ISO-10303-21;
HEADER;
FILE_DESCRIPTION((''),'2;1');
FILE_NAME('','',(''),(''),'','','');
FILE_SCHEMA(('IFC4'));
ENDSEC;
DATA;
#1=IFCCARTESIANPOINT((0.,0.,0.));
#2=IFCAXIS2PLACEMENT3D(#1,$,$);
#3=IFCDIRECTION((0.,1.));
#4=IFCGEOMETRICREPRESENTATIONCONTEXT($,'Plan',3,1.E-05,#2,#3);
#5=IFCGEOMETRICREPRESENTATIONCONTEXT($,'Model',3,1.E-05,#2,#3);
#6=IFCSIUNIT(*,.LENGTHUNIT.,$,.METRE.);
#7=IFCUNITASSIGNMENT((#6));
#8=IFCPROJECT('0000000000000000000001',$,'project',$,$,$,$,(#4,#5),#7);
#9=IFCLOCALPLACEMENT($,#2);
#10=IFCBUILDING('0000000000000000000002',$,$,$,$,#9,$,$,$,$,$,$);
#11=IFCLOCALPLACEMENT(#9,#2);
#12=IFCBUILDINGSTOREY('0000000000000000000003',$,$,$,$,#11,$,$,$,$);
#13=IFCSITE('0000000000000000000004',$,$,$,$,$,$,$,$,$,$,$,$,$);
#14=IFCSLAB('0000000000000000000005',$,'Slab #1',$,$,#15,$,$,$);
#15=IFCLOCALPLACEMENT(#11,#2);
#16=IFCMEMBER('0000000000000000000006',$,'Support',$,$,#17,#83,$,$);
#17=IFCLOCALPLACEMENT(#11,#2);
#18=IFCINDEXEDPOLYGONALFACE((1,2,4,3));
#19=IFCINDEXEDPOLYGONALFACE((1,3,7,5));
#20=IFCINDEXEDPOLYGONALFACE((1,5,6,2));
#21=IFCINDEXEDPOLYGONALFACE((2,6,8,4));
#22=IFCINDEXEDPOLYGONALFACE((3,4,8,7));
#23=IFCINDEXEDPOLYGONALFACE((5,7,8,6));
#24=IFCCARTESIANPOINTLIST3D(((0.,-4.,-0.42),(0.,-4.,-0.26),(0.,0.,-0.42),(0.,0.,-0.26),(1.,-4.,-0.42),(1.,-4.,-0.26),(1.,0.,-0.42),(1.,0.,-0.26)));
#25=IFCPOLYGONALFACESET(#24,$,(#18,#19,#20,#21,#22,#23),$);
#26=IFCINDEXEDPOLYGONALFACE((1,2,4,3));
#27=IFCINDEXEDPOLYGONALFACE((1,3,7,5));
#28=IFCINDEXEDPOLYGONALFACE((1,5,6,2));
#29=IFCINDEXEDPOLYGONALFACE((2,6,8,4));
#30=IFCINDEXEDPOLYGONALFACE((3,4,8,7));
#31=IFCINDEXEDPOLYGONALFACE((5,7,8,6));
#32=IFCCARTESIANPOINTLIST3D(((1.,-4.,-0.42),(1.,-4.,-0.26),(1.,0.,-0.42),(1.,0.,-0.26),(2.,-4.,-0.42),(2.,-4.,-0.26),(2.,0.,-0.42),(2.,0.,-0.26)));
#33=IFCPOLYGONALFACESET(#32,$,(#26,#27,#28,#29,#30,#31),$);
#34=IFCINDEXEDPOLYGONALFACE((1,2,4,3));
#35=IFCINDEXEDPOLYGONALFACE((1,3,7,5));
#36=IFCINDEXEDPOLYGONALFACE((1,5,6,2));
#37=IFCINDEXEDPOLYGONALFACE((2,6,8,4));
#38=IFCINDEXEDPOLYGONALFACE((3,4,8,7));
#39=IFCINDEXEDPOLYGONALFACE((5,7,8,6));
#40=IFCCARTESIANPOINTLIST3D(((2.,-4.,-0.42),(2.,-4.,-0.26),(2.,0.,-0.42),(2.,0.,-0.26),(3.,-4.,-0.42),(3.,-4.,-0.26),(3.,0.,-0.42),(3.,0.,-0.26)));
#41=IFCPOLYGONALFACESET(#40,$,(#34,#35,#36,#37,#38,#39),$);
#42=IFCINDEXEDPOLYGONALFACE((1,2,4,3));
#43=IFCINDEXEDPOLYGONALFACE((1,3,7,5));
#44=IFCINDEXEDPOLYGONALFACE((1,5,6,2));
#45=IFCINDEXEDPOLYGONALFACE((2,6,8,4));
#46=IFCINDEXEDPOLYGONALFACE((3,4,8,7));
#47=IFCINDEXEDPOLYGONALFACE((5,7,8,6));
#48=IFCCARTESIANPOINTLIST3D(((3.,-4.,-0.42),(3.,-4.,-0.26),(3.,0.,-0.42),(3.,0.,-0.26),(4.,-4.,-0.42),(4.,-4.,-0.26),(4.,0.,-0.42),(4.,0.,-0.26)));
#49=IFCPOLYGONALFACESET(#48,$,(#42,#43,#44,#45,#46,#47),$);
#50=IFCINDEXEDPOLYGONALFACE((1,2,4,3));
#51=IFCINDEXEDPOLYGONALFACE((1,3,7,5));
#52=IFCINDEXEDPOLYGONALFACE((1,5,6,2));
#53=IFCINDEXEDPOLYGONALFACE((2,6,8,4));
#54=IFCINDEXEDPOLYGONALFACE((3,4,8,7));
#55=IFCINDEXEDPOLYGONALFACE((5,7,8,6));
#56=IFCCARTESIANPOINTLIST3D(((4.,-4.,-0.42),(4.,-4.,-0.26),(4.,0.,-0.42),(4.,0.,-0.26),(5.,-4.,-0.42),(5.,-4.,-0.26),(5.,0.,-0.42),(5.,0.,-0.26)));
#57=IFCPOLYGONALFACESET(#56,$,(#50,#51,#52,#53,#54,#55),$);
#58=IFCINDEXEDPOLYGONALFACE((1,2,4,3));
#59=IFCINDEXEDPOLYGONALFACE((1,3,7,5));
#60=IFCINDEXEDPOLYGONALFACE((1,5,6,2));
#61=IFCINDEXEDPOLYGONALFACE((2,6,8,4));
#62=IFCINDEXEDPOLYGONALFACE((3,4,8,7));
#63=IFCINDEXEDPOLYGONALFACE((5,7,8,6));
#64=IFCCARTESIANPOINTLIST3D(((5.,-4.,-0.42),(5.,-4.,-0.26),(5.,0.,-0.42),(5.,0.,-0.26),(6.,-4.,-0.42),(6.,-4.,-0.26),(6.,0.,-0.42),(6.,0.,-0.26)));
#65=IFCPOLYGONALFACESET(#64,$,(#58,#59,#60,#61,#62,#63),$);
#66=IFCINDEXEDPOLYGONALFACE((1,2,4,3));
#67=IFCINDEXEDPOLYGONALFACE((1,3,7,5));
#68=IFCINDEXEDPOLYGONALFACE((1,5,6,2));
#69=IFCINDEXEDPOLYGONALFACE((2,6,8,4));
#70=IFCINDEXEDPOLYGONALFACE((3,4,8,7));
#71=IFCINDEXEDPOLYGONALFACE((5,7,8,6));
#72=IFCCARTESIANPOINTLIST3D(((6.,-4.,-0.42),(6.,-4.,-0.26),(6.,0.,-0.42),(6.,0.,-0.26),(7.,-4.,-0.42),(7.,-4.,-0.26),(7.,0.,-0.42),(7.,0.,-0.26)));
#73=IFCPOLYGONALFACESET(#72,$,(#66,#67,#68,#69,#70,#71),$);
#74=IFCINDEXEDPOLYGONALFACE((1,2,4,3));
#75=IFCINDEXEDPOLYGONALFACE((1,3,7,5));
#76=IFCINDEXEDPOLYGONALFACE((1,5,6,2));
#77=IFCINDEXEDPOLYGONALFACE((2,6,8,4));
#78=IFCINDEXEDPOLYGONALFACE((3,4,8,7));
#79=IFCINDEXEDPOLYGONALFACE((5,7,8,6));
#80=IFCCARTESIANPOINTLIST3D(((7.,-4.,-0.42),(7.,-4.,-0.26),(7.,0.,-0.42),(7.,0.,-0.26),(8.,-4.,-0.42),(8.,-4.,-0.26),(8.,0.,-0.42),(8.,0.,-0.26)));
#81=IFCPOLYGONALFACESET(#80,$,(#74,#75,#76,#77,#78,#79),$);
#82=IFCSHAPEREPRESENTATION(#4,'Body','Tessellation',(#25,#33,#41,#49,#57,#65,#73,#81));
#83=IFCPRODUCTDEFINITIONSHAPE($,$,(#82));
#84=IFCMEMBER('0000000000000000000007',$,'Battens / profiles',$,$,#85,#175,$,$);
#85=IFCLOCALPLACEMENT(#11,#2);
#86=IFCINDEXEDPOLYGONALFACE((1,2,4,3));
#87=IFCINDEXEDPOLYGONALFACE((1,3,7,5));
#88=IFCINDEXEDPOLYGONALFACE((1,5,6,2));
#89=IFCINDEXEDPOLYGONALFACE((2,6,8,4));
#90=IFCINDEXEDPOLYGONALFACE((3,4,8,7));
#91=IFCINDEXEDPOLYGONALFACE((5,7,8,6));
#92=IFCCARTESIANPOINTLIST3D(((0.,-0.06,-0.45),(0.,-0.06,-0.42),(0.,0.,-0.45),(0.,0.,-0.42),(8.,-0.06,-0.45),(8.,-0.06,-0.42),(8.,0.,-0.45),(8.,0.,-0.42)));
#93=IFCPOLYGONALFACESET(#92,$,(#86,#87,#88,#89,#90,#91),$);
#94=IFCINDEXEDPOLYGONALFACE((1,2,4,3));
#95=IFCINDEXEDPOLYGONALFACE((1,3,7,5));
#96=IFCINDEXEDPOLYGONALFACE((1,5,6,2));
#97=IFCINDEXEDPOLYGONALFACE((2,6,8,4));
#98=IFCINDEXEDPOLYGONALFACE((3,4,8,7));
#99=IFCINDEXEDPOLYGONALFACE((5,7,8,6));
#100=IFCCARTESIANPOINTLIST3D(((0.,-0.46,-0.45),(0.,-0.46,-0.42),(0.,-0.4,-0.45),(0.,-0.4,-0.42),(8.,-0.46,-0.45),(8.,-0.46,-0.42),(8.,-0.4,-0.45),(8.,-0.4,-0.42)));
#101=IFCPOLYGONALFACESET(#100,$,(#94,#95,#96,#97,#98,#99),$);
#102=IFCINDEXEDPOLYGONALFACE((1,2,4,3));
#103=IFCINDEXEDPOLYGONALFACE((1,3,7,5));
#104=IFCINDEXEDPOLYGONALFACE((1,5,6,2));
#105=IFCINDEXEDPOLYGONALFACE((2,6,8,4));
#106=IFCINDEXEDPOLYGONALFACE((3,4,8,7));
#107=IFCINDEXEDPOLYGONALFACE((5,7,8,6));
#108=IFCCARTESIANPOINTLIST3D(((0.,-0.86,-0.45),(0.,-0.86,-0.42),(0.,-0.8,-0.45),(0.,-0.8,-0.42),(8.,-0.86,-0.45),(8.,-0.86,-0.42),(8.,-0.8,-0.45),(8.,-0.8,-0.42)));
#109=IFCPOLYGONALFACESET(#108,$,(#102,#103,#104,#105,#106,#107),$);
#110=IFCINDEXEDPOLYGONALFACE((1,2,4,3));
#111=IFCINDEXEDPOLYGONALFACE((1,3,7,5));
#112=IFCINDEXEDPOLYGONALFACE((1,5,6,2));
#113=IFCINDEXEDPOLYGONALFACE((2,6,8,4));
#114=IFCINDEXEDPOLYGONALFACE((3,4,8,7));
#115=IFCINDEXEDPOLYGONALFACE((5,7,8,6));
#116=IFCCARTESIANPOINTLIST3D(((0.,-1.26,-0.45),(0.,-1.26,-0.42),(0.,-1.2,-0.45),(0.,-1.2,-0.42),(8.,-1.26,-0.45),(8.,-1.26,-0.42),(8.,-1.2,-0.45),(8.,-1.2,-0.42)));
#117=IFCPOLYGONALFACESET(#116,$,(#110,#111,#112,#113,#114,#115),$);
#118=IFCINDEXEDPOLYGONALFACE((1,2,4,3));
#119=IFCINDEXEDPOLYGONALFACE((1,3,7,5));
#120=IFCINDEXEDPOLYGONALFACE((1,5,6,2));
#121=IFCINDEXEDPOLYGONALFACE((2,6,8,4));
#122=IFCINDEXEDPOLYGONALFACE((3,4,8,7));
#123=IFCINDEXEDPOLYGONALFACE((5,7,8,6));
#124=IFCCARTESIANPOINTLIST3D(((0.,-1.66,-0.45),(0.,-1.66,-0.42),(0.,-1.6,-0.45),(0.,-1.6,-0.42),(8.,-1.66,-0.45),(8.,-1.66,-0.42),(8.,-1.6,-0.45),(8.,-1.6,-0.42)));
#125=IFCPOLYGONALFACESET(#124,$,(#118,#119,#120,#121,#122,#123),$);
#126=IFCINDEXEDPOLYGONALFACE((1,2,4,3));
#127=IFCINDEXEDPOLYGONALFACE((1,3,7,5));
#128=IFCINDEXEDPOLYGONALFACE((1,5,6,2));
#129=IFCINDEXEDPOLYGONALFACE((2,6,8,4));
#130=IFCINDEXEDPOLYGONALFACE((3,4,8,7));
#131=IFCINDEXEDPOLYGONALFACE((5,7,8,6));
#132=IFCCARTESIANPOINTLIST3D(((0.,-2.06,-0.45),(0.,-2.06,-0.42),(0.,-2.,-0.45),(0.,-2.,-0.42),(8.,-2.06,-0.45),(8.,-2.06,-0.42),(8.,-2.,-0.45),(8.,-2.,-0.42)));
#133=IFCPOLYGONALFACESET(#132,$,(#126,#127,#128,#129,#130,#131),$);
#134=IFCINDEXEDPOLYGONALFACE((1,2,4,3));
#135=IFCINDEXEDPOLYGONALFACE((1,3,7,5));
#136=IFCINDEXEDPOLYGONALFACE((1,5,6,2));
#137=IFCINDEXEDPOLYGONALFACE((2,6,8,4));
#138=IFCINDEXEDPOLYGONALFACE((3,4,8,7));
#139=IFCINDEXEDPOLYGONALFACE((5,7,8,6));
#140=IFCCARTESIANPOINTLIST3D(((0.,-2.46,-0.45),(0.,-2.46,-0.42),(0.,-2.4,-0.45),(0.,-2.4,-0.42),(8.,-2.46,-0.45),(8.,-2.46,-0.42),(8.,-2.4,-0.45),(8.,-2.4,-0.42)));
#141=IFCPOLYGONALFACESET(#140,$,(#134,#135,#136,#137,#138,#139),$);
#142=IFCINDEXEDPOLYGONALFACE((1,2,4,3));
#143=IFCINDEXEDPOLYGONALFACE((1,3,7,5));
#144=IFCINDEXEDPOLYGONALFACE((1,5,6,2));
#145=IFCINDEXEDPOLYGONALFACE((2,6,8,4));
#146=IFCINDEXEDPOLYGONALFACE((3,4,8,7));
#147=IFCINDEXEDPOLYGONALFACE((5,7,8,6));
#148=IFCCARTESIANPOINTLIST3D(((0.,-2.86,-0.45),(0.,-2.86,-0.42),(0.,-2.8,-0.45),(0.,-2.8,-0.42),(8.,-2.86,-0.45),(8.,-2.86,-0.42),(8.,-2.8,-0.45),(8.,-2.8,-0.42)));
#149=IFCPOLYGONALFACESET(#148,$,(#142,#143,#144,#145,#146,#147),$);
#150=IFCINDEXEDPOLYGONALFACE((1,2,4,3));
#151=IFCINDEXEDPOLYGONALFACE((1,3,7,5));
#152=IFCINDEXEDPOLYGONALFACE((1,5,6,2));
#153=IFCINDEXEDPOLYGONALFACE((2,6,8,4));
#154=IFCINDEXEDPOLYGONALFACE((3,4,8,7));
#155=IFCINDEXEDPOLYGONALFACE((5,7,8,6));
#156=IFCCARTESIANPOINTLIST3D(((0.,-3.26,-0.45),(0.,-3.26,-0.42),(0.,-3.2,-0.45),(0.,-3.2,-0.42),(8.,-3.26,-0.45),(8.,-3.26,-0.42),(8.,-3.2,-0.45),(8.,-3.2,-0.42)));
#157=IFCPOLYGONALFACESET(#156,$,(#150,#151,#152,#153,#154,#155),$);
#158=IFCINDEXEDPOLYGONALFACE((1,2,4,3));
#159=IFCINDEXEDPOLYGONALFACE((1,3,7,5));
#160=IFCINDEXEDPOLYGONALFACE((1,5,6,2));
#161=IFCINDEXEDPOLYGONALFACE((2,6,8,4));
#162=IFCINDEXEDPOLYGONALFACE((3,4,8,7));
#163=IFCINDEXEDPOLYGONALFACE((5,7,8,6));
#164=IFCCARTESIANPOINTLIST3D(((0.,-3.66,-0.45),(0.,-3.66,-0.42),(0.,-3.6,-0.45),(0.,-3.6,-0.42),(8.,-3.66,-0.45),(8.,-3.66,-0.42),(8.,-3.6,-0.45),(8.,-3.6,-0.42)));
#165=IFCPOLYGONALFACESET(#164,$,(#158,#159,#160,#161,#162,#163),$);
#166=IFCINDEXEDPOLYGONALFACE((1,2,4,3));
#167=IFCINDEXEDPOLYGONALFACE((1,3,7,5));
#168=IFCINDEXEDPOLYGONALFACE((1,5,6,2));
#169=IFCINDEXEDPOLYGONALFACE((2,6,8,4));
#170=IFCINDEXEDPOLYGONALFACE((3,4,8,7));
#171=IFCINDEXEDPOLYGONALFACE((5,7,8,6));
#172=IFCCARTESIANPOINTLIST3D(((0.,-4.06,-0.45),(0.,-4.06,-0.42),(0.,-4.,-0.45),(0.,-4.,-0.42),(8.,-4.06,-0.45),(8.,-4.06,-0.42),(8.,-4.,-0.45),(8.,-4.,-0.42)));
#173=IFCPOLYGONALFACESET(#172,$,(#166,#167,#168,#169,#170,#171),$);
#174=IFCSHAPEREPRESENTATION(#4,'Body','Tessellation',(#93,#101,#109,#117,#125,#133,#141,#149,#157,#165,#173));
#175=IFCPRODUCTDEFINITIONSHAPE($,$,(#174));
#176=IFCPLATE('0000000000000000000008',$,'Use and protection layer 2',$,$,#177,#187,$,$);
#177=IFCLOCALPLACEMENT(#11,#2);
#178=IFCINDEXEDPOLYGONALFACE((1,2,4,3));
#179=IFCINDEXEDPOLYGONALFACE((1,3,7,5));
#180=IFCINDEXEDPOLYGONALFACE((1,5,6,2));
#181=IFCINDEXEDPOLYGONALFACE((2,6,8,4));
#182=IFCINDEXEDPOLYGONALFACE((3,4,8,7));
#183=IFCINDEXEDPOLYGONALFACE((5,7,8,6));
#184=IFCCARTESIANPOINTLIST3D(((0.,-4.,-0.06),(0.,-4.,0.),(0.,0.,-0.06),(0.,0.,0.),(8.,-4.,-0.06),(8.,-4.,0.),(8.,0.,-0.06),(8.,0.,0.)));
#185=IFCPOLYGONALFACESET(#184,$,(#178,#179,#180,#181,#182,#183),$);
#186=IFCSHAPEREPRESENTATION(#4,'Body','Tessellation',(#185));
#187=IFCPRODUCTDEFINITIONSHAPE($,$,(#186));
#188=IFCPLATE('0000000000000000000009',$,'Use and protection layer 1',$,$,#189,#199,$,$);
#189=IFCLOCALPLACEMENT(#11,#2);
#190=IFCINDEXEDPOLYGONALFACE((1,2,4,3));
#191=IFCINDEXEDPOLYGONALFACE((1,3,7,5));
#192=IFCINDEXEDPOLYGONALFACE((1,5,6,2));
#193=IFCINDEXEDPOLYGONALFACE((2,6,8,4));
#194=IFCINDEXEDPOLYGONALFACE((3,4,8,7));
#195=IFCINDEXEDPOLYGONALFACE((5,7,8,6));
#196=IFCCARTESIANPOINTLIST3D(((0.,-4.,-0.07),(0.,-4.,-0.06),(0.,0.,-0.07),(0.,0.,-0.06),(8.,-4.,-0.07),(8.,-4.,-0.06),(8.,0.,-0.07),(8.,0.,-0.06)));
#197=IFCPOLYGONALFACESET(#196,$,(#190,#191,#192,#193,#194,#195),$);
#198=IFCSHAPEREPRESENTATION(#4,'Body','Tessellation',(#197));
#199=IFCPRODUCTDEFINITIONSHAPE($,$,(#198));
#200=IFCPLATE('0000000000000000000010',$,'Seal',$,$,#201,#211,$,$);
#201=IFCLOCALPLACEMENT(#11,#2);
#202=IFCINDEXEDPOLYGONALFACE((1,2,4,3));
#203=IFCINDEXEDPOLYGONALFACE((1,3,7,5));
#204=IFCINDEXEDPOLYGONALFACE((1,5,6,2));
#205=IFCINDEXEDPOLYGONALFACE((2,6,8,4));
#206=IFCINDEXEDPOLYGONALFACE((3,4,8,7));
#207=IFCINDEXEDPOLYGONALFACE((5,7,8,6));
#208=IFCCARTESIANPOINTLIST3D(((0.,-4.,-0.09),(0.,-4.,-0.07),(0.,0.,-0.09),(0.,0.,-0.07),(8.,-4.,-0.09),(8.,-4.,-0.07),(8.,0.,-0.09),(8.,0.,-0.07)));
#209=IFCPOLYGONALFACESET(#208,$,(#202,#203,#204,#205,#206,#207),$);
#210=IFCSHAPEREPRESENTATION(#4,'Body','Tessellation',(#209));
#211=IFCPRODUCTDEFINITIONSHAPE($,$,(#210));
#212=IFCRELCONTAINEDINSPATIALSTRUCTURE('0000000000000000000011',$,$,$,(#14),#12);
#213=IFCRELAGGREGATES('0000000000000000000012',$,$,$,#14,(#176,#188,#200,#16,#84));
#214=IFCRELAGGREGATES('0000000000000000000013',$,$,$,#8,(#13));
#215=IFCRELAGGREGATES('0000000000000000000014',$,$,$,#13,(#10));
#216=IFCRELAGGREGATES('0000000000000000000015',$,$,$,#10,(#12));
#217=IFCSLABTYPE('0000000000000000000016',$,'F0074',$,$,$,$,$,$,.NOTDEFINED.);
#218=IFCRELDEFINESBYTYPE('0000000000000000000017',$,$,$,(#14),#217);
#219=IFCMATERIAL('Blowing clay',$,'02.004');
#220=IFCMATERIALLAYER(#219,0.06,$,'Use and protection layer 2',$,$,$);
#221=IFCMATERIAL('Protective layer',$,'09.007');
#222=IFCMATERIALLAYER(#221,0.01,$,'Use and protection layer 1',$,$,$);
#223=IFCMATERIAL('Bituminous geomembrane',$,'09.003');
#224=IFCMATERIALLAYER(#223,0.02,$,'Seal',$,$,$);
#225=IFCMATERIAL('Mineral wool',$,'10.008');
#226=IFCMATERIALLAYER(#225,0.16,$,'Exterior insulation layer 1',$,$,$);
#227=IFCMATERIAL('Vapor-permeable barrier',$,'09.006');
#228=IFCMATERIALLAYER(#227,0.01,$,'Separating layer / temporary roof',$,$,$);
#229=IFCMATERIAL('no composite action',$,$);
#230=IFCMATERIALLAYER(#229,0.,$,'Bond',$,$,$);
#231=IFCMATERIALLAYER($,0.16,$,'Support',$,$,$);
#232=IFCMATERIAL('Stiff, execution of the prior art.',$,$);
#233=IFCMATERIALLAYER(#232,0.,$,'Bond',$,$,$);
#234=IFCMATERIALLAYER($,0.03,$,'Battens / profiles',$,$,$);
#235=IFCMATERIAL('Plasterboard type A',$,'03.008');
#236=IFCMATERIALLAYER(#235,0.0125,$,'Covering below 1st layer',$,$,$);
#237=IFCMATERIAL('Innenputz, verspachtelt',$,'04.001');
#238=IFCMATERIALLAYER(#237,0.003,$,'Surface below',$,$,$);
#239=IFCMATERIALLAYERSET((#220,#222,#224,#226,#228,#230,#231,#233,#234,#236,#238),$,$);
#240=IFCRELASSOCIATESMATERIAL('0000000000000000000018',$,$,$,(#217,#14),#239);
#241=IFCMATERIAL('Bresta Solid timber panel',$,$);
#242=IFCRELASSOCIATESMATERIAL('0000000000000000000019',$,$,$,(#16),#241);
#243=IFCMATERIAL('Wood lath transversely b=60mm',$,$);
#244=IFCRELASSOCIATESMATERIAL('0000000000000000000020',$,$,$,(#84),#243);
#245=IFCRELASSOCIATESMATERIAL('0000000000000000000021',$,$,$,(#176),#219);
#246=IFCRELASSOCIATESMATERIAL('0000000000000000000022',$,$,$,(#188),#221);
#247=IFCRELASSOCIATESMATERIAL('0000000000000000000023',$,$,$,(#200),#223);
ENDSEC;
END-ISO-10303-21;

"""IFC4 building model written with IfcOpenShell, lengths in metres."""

from ifc_helpers import new_model, si_unit, direction, frame, frame_2d, origin, origin_with_axes, place, context, project, spatial, rectangle, extrude, material, layer, layer_set, type_object, element, aggregate, save


model = new_model("IFC4")

# Units and contexts
plan_context = context("Plan", 3, precision=1e-05, world=origin(), true_north=direction((0.0, 1.0)))
model_context = context("Model", 3, precision=1e-05, world=origin(), true_north=direction((0.0, 1.0)))
ifc_project = project(units=[si_unit("LENGTHUNIT", "METRE")], contexts=[plan_context, model_context])

# Site, building, storey
site = spatial("IfcSite", under=ifc_project)
building_placement = place(None, origin())
building = spatial("IfcBuilding", under=site, at=building_placement)
storey_placement = place(building_placement, origin())
storey = spatial("IfcBuildingStorey", under=building, at=storey_placement)

# Slab, members, plates
ifc_material_1 = material(Name="Blowing clay", Category="02.004")
ifc_layer_1 = layer(ifc_material_1, 0.06, Name="Use and protection layer 2")
ifc_material_2 = material(Name="Protective layer", Category="09.007")
ifc_layer_2 = layer(ifc_material_2, 0.01, Name="Use and protection layer 1")
ifc_material_3 = material(Name="Bituminous geomembrane", Category="09.003")
ifc_layer_3 = layer(ifc_material_3, 0.02, Name="Seal")
ifc_material_4 = material(Name="Mineral wool", Category="10.008")
ifc_layer_4 = layer(ifc_material_4, 0.16, Name="Exterior insulation layer 1")
ifc_material_5 = material(Name="Vapor-permeable barrier", Category="09.006")
ifc_layer_5 = layer(ifc_material_5, 0.01, Name="Separating layer / temporary roof")
ifc_material_6 = material(Name="no composite action")
ifc_layer_6 = layer(ifc_material_6, 0.0, Name="Bond")
ifc_layer_7 = layer(None, 0.16, Name="Support")
ifc_material_7 = material(Name="Stiff, execution of the prior art.")
ifc_layer_8 = layer(ifc_material_7, 0.0, Name="Bond")
ifc_layer_9 = layer(None, 0.03, Name="Battens / profiles")
ifc_material_8 = material(Name="Plasterboard type A", Category="03.008")
ifc_layer_10 = layer(ifc_material_8, 0.0125, Name="Covering below 1st layer")
ifc_material_9 = material(Name="Innenputz, verspachtelt", Category="04.001")
ifc_layer_11 = layer(ifc_material_9, 0.003, Name="Surface below")
ifc_layer_set = layer_set([ifc_layer_1, ifc_layer_2, ifc_layer_3, ifc_layer_4, ifc_layer_5, ifc_layer_6, ifc_layer_7, ifc_layer_8, ifc_layer_9, ifc_layer_10, ifc_layer_11])
slab_type = type_object("IfcSlabType", Name="F0074", PredefinedType="NOTDEFINED", material=ifc_layer_set)
slab_placement = place(None, frame((0.0, 0.0, 0.0), z_axis=(0.0, 0.0, -1.0), x_axis=(1.0, 0.0, 0.0)))
slab = element("IfcSlab", 1, at=slab_placement, inside=storey, type_object=slab_type, material=ifc_layer_set, Name="Slab #1")
ifc_material_10 = material(Name="Bresta Solid timber panel")
member_1_placement = place(slab_placement, origin())
member_1 = element("IfcMember", 2, at=member_1_placement, material=ifc_material_10, Name="Support", context=plan_context, shape_type="SweptSolid", body=[
    extrude(rectangle(XDim=1.0, YDim=0.16, at=frame_2d((0.5, 0.08), x_axis=(1.0, 0.0))), frame((0.0, 4.0, 0.26), z_axis=(0.0, -1.0, 0.0), x_axis=(1.0, 0.0, 0.0)), (0.0, 0.0, 1.0), 4.0),
    extrude(rectangle(XDim=1.0, YDim=0.16, at=frame_2d((0.5, 0.08), x_axis=(1.0, 0.0))), frame((1.0, 4.0, 0.26), z_axis=(0.0, -1.0, 0.0), x_axis=(1.0, 0.0, 0.0)), (0.0, 0.0, 1.0), 4.0),
    extrude(rectangle(XDim=1.0, YDim=0.16, at=frame_2d((0.5, 0.08), x_axis=(1.0, 0.0))), frame((2.0, 4.0, 0.26), z_axis=(0.0, -1.0, 0.0), x_axis=(1.0, 0.0, 0.0)), (0.0, 0.0, 1.0), 4.0),
    extrude(rectangle(XDim=1.0, YDim=0.16, at=frame_2d((0.5, 0.08), x_axis=(1.0, 0.0))), frame((3.0, 4.0, 0.26), z_axis=(0.0, -1.0, 0.0), x_axis=(1.0, 0.0, 0.0)), (0.0, 0.0, 1.0), 4.0),
    extrude(rectangle(XDim=1.0, YDim=0.16, at=frame_2d((0.5, 0.08), x_axis=(1.0, 0.0))), frame((4.0, 4.0, 0.26), z_axis=(0.0, -1.0, 0.0), x_axis=(1.0, 0.0, 0.0)), (0.0, 0.0, 1.0), 4.0),
    extrude(rectangle(XDim=1.0, YDim=0.16, at=frame_2d((0.5, 0.08), x_axis=(1.0, 0.0))), frame((5.0, 4.0, 0.26), z_axis=(0.0, -1.0, 0.0), x_axis=(1.0, 0.0, 0.0)), (0.0, 0.0, 1.0), 4.0),
    extrude(rectangle(XDim=1.0, YDim=0.16, at=frame_2d((0.5, 0.08), x_axis=(1.0, 0.0))), frame((6.0, 4.0, 0.26), z_axis=(0.0, -1.0, 0.0), x_axis=(1.0, 0.0, 0.0)), (0.0, 0.0, 1.0), 4.0),
    extrude(rectangle(XDim=1.0, YDim=0.16, at=frame_2d((0.5, 0.08), x_axis=(1.0, 0.0))), frame((7.0, 4.0, 0.26), z_axis=(0.0, -1.0, 0.0), x_axis=(1.0, 0.0, 0.0)), (0.0, 0.0, 1.0), 4.0),
])
ifc_material_11 = material(Name="Wood lath transversely b=60mm")
member_2_placement = place(slab_placement, origin())
member_2 = element("IfcMember", 3, at=member_2_placement, material=ifc_material_11, Name="Battens / profiles", context=plan_context, shape_type="SweptSolid", body=[
    extrude(rectangle(XDim=0.06, YDim=0.03, at=frame_2d((0.03, 0.015), x_axis=(1.0, 0.0))), frame((0.0, 0.0, 0.42), z_axis=(1.0, 0.0, 0.0), x_axis=(0.0, 1.0, 0.0)), (0.0, 0.0, 1.0), 8.0),
    extrude(rectangle(XDim=0.06, YDim=0.03, at=frame_2d((0.03, 0.015), x_axis=(1.0, 0.0))), frame((0.0, 0.4, 0.42), z_axis=(1.0, 0.0, 0.0), x_axis=(0.0, 1.0, 0.0)), (0.0, 0.0, 1.0), 8.0),
    extrude(rectangle(XDim=0.06, YDim=0.03, at=frame_2d((0.03, 0.015), x_axis=(1.0, 0.0))), frame((0.0, 0.8, 0.42), z_axis=(1.0, 0.0, 0.0), x_axis=(0.0, 1.0, 0.0)), (0.0, 0.0, 1.0), 8.0),
    extrude(rectangle(XDim=0.06, YDim=0.03, at=frame_2d((0.03, 0.015), x_axis=(1.0, 0.0))), frame((0.0, 1.2, 0.42), z_axis=(1.0, 0.0, 0.0), x_axis=(0.0, 1.0, 0.0)), (0.0, 0.0, 1.0), 8.0),
    extrude(rectangle(XDim=0.06, YDim=0.03, at=frame_2d((0.03, 0.015), x_axis=(1.0, 0.0))), frame((0.0, 1.6, 0.42), z_axis=(1.0, 0.0, 0.0), x_axis=(0.0, 1.0, 0.0)), (0.0, 0.0, 1.0), 8.0),
    extrude(rectangle(XDim=0.06, YDim=0.03, at=frame_2d((0.03, 0.015), x_axis=(1.0, 0.0))), frame((0.0, 2.0, 0.42), z_axis=(1.0, 0.0, 0.0), x_axis=(0.0, 1.0, 0.0)), (0.0, 0.0, 1.0), 8.0),
    extrude(rectangle(XDim=0.06, YDim=0.03, at=frame_2d((0.03, 0.015), x_axis=(1.0, 0.0))), frame((0.0, 2.4, 0.42), z_axis=(1.0, 0.0, 0.0), x_axis=(0.0, 1.0, 0.0)), (0.0, 0.0, 1.0), 8.0),
    extrude(rectangle(XDim=0.06, YDim=0.03, at=frame_2d((0.03, 0.015), x_axis=(1.0, 0.0))), frame((0.0, 2.8, 0.42), z_axis=(1.0, 0.0, 0.0), x_axis=(0.0, 1.0, 0.0)), (0.0, 0.0, 1.0), 8.0),
    extrude(rectangle(XDim=0.06, YDim=0.03, at=frame_2d((0.03, 0.015), x_axis=(1.0, 0.0))), frame((0.0, 3.2, 0.42), z_axis=(1.0, 0.0, 0.0), x_axis=(0.0, 1.0, 0.0)), (0.0, 0.0, 1.0), 8.0),
    extrude(rectangle(XDim=0.06, YDim=0.03, at=frame_2d((0.03, 0.015), x_axis=(1.0, 0.0))), frame((0.0, 3.6, 0.42), z_axis=(1.0, 0.0, 0.0), x_axis=(0.0, 1.0, 0.0)), (0.0, 0.0, 1.0), 8.0),
    extrude(rectangle(XDim=0.06, YDim=0.03, at=frame_2d((0.03, 0.015), x_axis=(1.0, 0.0))), frame((0.0, 4.0, 0.42), z_axis=(1.0, 0.0, 0.0), x_axis=(0.0, 1.0, 0.0)), (0.0, 0.0, 1.0), 8.0),
])
plate_1_placement = place(slab_placement, origin())
plate_1 = element("IfcPlate", 4, at=plate_1_placement, material=ifc_material_1, Name="Use and protection layer 2", context=plan_context, shape_type="SweptSolid", body=[
    extrude(rectangle(XDim=8.0, YDim=4.0, at=frame_2d((4.0, 2.0), x_axis=(1.0, 0.0))), origin_with_axes(), (0.0, 0.0, 1.0), 0.06),
])
plate_2_placement = place(slab_placement, origin())
plate_2 = element("IfcPlate", 5, at=plate_2_placement, material=ifc_material_2, Name="Use and protection layer 1", context=plan_context, shape_type="SweptSolid", body=[
    extrude(rectangle(XDim=8.0, YDim=4.0, at=frame_2d((4.0, 2.0), x_axis=(1.0, 0.0))), frame((0.0, 0.0, 0.06), z_axis=(0.0, 0.0, 1.0), x_axis=(1.0, 0.0, 0.0)), (0.0, 0.0, 1.0), 0.01),
])
plate_3_placement = place(slab_placement, origin())
plate_3 = element("IfcPlate", 6, at=plate_3_placement, material=ifc_material_3, Name="Seal", context=plan_context, shape_type="SweptSolid", body=[
    extrude(rectangle(XDim=8.0, YDim=4.0, at=frame_2d((4.0, 2.0), x_axis=(1.0, 0.0))), frame((0.0, 0.0, 0.07), z_axis=(0.0, 0.0, 1.0), x_axis=(1.0, 0.0, 0.0)), (0.0, 0.0, 1.0), 0.02),
])
aggregate(slab, [plate_1, plate_2, plate_3, member_1, member_2])

save(model, "model.ifc")
